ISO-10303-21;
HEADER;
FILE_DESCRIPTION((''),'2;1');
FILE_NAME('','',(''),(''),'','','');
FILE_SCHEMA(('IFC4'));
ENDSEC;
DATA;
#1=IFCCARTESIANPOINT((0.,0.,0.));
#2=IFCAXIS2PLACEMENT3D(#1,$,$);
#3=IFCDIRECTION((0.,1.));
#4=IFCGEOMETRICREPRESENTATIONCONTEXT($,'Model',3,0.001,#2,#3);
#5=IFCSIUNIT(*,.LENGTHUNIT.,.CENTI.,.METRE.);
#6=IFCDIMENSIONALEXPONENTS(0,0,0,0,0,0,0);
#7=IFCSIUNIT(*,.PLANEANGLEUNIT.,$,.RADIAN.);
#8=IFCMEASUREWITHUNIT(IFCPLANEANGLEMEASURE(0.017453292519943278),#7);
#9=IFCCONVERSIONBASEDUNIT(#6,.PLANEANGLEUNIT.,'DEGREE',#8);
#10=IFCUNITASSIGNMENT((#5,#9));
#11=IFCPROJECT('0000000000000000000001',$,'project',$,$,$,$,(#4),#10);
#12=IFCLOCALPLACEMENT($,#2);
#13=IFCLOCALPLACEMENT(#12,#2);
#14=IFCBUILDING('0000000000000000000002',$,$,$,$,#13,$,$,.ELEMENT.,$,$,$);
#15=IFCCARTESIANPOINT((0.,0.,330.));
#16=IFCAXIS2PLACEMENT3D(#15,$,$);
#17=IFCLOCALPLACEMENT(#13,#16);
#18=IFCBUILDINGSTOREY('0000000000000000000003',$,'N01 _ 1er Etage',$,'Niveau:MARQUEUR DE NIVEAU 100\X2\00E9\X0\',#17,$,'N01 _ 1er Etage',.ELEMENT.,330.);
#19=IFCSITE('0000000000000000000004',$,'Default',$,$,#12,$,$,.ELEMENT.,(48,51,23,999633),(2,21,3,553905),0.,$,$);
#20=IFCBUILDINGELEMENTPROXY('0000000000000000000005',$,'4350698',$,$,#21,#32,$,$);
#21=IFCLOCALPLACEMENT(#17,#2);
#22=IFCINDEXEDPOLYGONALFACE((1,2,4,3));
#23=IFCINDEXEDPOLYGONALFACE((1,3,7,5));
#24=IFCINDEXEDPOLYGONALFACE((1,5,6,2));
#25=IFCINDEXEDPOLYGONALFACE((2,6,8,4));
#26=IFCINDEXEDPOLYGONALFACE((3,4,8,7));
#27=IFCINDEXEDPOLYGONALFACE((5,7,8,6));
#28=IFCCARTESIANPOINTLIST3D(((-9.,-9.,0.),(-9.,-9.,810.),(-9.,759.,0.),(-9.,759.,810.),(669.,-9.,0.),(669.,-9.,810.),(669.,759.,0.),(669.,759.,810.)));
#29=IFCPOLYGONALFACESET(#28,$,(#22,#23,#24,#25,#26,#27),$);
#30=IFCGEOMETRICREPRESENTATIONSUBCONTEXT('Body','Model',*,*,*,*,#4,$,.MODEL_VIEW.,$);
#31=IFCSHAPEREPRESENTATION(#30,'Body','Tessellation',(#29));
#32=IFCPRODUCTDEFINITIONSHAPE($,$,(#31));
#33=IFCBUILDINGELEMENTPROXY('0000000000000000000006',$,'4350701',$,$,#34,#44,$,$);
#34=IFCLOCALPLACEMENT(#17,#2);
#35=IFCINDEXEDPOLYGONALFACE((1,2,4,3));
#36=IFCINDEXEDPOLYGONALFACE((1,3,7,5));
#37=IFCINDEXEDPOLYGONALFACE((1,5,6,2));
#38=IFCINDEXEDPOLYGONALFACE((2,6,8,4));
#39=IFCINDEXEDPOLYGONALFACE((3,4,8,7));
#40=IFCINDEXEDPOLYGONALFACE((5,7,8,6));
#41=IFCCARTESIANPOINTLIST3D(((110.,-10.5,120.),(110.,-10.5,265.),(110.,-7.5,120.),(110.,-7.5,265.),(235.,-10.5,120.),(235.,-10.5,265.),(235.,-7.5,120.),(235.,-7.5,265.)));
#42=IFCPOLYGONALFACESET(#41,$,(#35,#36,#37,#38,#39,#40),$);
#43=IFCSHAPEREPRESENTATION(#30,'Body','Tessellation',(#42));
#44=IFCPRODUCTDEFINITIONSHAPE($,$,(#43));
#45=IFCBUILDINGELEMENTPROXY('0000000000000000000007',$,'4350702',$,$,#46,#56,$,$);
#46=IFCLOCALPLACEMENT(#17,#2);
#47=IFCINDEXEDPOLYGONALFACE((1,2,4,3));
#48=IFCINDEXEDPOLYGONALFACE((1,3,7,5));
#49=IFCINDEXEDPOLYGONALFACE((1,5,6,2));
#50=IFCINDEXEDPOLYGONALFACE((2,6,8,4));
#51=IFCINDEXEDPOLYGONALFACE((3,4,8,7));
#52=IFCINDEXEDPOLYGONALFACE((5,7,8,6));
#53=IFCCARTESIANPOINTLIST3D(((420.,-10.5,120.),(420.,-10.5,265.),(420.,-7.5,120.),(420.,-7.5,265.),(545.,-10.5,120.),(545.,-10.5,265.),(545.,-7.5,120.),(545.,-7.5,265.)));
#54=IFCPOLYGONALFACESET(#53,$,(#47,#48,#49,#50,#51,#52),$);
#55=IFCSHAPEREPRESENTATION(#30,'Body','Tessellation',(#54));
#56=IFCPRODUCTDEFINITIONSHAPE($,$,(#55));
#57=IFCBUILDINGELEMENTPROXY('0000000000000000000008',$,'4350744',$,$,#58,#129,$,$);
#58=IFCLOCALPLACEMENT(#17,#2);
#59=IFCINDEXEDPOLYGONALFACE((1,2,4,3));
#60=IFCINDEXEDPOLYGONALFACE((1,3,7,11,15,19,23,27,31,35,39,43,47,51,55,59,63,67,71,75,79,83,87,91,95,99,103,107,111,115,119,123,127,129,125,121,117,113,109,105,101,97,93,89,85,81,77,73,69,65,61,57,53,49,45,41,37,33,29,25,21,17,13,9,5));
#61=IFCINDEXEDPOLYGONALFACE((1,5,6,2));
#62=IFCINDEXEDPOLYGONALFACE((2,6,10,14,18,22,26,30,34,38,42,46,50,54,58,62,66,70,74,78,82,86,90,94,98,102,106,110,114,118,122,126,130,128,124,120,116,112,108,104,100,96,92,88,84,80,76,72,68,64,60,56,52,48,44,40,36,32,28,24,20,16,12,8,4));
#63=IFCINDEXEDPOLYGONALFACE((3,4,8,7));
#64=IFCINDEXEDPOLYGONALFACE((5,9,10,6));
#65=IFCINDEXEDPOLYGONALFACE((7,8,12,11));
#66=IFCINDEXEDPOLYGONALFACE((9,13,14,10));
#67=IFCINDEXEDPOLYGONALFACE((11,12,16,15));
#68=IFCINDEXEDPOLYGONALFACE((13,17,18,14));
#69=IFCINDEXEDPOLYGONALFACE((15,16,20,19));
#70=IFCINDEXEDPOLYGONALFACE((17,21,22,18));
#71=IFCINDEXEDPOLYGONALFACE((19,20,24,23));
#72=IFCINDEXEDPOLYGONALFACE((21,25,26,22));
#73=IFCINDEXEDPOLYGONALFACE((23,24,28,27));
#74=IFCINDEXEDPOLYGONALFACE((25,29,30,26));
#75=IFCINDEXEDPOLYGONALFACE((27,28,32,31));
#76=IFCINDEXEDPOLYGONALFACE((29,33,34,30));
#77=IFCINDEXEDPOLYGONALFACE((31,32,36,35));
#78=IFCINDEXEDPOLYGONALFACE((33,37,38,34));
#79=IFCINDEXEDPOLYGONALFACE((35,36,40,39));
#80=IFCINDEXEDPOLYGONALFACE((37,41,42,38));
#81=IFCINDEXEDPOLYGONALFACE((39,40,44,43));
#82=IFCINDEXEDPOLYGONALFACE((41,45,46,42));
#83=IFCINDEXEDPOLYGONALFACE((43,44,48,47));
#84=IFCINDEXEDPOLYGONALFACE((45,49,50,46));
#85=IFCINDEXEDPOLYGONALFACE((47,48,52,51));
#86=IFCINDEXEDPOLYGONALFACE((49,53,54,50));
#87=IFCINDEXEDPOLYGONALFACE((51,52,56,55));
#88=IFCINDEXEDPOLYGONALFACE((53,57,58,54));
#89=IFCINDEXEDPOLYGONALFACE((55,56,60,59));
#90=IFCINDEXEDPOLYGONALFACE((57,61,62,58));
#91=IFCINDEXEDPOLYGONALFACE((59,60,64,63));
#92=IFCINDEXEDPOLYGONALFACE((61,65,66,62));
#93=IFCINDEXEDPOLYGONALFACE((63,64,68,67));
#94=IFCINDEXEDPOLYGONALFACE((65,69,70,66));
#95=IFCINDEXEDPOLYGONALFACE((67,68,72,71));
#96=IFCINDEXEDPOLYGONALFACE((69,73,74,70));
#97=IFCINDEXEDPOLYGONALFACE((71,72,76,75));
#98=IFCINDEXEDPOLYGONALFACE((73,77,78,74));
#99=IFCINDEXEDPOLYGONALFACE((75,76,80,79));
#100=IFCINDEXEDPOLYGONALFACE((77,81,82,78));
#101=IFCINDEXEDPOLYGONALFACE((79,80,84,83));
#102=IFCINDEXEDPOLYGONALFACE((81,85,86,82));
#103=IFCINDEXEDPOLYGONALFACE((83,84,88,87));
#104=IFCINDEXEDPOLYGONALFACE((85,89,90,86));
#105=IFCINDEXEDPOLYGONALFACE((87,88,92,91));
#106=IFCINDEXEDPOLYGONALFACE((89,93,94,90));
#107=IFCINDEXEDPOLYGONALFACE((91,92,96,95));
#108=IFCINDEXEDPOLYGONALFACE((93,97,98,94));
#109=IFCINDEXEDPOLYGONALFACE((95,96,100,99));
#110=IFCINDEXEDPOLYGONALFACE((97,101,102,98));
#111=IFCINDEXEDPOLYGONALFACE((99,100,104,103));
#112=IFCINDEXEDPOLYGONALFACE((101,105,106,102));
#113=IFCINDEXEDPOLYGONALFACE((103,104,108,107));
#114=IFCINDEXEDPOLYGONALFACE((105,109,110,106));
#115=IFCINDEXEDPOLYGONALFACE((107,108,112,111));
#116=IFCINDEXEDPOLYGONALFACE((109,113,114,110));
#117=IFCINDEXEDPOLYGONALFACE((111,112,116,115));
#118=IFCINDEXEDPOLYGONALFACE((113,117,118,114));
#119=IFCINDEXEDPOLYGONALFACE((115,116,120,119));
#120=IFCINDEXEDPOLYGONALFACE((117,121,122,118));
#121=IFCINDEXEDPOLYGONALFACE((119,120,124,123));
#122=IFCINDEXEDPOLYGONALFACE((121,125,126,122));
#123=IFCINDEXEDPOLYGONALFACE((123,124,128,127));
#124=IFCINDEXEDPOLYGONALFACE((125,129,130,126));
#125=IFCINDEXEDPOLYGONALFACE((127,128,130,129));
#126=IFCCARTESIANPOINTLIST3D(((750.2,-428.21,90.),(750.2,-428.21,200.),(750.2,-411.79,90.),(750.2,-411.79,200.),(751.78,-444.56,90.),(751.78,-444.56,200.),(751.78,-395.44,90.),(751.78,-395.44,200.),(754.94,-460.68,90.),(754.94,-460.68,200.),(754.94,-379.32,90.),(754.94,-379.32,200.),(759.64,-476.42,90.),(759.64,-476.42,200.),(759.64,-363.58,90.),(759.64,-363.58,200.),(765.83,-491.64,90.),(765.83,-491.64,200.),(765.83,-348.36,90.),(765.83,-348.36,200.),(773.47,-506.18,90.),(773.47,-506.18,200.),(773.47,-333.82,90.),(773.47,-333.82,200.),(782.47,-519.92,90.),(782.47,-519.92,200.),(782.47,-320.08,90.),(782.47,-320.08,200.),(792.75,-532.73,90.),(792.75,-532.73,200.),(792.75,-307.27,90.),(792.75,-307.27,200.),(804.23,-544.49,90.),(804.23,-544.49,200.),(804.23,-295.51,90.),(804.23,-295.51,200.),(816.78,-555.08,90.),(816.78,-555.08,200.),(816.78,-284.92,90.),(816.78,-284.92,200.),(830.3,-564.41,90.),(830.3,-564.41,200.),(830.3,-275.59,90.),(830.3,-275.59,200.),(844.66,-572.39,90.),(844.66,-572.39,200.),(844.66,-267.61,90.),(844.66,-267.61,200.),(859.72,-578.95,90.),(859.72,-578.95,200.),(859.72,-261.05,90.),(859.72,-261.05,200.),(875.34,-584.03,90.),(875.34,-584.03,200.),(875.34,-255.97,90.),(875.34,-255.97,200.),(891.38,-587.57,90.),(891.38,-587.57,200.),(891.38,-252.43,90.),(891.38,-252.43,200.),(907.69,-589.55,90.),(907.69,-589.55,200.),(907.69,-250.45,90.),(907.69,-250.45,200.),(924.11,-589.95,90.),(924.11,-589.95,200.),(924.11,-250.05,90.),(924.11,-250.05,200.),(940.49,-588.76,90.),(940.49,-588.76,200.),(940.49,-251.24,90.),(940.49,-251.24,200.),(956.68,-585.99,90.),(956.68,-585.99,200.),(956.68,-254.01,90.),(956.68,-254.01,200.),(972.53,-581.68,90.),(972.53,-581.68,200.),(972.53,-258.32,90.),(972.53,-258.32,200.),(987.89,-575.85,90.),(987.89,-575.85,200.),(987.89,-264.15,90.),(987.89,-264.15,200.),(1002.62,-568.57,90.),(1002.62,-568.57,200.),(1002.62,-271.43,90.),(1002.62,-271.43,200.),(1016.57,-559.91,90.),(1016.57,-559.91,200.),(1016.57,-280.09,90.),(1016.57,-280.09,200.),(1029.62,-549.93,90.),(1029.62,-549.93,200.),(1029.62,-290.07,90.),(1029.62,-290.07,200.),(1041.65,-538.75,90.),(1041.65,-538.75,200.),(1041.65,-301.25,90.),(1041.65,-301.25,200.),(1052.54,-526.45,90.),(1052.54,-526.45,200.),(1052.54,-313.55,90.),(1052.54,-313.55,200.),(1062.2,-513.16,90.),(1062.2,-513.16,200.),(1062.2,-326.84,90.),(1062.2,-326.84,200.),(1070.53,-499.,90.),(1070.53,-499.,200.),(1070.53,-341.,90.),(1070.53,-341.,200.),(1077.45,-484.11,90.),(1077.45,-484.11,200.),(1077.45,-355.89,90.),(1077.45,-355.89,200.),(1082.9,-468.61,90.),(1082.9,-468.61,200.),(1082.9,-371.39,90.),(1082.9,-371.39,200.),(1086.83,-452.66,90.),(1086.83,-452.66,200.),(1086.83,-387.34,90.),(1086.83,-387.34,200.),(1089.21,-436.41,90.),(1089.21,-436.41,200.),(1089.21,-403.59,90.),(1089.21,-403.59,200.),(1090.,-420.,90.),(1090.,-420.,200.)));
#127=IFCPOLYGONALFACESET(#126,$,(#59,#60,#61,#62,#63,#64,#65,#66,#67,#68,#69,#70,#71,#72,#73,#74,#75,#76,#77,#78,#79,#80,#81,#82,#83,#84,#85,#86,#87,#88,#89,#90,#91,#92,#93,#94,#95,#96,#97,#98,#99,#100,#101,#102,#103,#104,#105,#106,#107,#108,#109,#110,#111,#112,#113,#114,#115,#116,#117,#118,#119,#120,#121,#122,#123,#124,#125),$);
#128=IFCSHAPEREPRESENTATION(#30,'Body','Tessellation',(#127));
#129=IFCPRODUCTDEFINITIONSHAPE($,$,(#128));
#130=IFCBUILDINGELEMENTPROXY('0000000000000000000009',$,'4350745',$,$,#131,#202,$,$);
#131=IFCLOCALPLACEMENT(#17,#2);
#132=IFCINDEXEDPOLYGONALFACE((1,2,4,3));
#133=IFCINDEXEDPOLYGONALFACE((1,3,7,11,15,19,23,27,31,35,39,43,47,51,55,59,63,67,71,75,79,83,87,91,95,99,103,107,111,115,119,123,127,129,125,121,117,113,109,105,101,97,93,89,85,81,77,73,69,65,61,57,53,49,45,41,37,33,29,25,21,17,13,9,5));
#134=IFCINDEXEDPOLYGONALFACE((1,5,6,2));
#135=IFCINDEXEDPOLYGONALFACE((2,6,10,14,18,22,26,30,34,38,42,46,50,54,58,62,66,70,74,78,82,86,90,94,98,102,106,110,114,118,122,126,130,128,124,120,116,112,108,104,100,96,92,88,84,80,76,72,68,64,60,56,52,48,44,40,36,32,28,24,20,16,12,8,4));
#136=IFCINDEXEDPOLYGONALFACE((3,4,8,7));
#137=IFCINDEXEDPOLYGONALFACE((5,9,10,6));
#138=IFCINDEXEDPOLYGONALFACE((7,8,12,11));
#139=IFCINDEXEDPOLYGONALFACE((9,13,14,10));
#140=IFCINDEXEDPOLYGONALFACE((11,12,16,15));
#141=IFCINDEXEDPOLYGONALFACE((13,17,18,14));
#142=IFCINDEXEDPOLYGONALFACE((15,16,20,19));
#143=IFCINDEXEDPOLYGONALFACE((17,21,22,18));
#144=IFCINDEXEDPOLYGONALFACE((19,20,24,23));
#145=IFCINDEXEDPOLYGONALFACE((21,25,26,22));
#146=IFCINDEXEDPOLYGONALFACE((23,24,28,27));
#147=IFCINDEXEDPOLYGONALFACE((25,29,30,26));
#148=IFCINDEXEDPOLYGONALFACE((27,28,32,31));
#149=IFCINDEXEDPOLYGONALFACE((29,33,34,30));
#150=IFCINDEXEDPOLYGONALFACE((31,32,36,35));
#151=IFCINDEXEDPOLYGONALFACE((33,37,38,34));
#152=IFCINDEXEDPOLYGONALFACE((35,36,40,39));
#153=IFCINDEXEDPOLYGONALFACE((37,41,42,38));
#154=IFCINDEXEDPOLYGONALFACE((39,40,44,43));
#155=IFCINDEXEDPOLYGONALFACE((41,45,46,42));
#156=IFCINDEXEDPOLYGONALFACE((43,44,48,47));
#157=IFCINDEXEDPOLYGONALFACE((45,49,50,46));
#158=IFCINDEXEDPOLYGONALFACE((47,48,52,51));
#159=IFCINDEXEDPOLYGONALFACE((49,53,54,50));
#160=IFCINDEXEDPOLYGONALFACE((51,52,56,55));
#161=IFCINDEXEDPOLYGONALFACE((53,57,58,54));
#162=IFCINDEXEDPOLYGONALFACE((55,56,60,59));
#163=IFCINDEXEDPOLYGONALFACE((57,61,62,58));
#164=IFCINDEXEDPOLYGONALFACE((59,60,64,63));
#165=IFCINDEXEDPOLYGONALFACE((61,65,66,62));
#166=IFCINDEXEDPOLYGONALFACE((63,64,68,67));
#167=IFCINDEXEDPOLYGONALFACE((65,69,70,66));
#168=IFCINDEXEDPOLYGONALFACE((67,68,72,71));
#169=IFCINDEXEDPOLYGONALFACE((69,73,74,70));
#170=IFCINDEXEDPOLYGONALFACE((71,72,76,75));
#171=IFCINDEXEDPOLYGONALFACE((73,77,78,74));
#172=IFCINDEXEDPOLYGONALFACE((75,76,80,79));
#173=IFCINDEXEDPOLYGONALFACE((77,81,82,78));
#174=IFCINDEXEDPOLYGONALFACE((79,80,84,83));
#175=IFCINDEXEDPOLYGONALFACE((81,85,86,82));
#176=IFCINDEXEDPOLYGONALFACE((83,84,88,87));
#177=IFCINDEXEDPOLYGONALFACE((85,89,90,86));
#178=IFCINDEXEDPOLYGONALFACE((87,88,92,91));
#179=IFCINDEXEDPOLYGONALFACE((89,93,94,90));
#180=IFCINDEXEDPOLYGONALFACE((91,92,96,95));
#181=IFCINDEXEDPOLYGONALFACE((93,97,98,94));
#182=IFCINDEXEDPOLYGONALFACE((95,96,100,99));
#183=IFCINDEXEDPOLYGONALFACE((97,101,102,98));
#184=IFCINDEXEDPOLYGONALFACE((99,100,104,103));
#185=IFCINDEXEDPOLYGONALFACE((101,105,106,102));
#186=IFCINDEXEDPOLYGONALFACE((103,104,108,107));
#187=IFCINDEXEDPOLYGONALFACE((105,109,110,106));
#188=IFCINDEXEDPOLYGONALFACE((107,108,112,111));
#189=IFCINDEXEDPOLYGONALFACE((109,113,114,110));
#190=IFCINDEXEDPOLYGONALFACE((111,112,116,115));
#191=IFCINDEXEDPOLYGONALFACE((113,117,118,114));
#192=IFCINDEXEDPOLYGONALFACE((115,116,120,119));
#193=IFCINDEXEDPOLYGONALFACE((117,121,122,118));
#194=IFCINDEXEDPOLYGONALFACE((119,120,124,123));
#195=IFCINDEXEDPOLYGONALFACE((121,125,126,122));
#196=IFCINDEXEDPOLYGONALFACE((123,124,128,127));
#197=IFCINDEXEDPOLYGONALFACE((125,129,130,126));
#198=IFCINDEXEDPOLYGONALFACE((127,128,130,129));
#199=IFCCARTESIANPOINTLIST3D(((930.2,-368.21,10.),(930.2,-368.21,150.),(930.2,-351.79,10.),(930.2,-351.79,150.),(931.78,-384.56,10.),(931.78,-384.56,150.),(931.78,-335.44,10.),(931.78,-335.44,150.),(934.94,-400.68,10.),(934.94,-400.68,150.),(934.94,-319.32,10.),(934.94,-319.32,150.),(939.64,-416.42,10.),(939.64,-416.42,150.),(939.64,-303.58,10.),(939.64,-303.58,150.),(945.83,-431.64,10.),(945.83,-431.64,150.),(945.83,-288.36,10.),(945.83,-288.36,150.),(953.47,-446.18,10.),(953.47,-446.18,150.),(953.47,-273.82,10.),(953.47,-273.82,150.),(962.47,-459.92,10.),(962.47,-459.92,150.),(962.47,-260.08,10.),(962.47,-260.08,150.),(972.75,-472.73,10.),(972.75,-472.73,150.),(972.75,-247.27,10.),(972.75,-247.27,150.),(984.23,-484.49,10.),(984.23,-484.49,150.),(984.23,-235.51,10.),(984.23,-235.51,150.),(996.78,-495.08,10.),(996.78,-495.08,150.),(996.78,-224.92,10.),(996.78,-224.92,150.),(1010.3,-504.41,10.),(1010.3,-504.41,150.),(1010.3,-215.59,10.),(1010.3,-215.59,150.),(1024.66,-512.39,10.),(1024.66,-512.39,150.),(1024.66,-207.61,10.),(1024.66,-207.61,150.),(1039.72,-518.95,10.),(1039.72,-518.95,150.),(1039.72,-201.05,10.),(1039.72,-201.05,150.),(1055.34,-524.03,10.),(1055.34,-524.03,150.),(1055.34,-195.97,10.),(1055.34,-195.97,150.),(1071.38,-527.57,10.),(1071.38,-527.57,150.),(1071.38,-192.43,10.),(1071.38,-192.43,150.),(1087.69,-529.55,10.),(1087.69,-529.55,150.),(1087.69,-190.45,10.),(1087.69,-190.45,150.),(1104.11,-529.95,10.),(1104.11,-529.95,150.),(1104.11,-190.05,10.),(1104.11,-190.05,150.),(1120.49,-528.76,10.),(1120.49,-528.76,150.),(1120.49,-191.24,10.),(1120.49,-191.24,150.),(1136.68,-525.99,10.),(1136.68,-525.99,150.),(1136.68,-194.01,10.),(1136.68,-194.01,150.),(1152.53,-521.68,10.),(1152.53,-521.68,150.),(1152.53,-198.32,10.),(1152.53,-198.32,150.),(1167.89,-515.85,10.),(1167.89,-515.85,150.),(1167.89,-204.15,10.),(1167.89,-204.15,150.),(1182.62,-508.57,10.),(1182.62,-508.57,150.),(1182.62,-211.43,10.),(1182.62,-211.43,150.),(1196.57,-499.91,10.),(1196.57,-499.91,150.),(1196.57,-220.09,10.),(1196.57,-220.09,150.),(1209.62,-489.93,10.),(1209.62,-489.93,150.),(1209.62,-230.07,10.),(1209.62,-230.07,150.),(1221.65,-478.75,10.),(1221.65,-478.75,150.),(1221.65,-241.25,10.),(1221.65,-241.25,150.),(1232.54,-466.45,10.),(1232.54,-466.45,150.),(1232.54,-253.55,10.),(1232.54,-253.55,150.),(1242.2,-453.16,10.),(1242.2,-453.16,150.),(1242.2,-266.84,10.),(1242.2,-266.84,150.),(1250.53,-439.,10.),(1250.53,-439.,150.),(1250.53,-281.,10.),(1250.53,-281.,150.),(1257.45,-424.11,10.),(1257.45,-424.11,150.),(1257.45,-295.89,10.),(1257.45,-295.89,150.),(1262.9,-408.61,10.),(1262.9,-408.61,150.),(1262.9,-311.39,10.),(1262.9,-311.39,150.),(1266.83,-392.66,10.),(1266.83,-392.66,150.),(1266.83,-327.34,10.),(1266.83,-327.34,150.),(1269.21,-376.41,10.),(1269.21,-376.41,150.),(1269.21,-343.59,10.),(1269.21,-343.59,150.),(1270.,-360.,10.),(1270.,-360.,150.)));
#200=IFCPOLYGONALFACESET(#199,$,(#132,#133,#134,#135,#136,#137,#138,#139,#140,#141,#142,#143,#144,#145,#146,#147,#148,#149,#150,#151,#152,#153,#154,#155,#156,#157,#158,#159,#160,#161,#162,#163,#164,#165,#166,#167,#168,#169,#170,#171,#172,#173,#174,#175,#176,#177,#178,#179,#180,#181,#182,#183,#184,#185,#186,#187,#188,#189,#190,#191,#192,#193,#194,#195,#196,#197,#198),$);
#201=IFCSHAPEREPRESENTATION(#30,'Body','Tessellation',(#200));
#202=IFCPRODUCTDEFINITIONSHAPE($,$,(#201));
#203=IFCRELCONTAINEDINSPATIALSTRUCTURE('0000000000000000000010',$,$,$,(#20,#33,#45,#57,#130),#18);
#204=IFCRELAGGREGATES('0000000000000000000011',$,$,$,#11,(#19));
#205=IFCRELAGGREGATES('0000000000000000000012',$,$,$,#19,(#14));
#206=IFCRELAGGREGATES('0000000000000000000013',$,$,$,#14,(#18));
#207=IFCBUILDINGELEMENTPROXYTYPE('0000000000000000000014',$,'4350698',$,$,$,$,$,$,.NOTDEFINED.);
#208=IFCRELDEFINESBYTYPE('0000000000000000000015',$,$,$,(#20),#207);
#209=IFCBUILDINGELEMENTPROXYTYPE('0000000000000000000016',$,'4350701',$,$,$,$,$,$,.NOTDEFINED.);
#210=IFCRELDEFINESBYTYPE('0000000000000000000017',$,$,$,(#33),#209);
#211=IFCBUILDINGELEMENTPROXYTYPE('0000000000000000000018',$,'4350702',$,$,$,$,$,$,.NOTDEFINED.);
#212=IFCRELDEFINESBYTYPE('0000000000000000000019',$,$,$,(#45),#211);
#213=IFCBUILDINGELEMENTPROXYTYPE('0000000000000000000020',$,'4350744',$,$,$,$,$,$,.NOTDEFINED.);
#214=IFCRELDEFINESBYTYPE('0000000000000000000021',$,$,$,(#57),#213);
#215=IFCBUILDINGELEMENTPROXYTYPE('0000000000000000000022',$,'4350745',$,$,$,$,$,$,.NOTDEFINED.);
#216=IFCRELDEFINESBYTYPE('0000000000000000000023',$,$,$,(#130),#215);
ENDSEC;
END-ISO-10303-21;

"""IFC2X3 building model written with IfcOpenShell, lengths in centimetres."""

from ifc_helpers import new_model, entity, si_unit, converted_unit, direction, frame, frame_2d, origin, origin_2d_with_axis, place, context, subcontext, project, spatial, rectangle, circle, extrude, type_object, element, save


model = new_model("IFC2X3")

# Units and contexts
model_context = context("Model", 3, precision=0.001, world=origin(), true_north=direction((0.0, 1.0)))
body_context = subcontext(model_context, "Body", "Model", "MODEL_VIEW")
ifc_project = project(units=[si_unit("LENGTHUNIT", "METRE", prefix="CENTI"), converted_unit("PLANEANGLEUNIT", "DEGREE", entity("IfcPlaneAngleMeasure", 0.017453292519943278), si_unit("PLANEANGLEUNIT", "RADIAN"), dimensions=[0, 0, 0, 0, 0, 0, 0])], contexts=[model_context])

# Site, building, storey
site_placement = place(None, origin())
site = spatial("IfcSite", under=ifc_project, at=site_placement, Name="Default", CompositionType="ELEMENT", RefLatitude=(48, 51, 23, 999633), RefLongitude=(2, 21, 3, 553905), RefElevation=0.0)
building_placement = place(site_placement, origin())
building = spatial("IfcBuilding", under=site, at=building_placement, CompositionType="ELEMENT")
storey_placement = place(building_placement, frame((0.0, 0.0, 330.0)))
storey = spatial("IfcBuildingStorey", under=building, at=storey_placement, Name="N01 _ 1er Etage", ObjectType="Niveau:MARQUEUR DE NIVEAU 100é", LongName="N01 _ 1er Etage", CompositionType="ELEMENT", Elevation=330.0)

# Building element proxies
building_element_proxy_type_1 = type_object("IfcBuildingElementProxyType", Name="4350698", PredefinedType="NOTDEFINED")
proxy_1_placement = place(storey_placement, origin())
element("IfcBuildingElementProxy", 1, at=proxy_1_placement, inside=storey, type_object=building_element_proxy_type_1, Name="4350698", context=body_context, shape_type="SweptSolid", body=[
    extrude(rectangle(XDim=678.0, YDim=768.0, at=origin_2d_with_axis()), frame((330.0, 375.0, 0.0)), (0.0, 0.0, 1.0), 810.0),
])
building_element_proxy_type_2 = type_object("IfcBuildingElementProxyType", Name="4350701", PredefinedType="NOTDEFINED")
proxy_2_placement = place(storey_placement, origin())
element("IfcBuildingElementProxy", 2, at=proxy_2_placement, inside=storey, type_object=building_element_proxy_type_2, Name="4350701", context=body_context, shape_type="SweptSolid", body=[
    extrude(rectangle(XDim=125.0, YDim=3.0, at=frame_2d((0.0, 0.0), x_axis=(1.0, 0.0))), frame((172.5, -9.0, 120.0)), (0.0, 0.0, 1.0), 145.0),
])
building_element_proxy_type_3 = type_object("IfcBuildingElementProxyType", Name="4350702", PredefinedType="NOTDEFINED")
proxy_3_placement = place(storey_placement, origin())
element("IfcBuildingElementProxy", 3, at=proxy_3_placement, inside=storey, type_object=building_element_proxy_type_3, Name="4350702", context=body_context, shape_type="SweptSolid", body=[
    extrude(rectangle(XDim=125.0, YDim=3.0, at=frame_2d((0.0, 0.0), x_axis=(1.0, 0.0))), frame((482.5, -9.0, 120.0)), (0.0, 0.0, 1.0), 145.0),
])
building_element_proxy_type_4 = type_object("IfcBuildingElementProxyType", Name="4350744", PredefinedType="NOTDEFINED")
proxy_4_placement = place(storey_placement, origin())
element("IfcBuildingElementProxy", 4, at=proxy_4_placement, inside=storey, type_object=building_element_proxy_type_4, Name="4350744", context=body_context, shape_type="SweptSolid", body=[
    extrude(circle(Radius=170.0, at=origin_2d_with_axis()), frame((920.0, -420.0, 90.0)), (0.0, 0.0, 1.0), 110.0),
])
building_element_proxy_type_5 = type_object("IfcBuildingElementProxyType", Name="4350745", PredefinedType="NOTDEFINED")
proxy_5_placement = place(storey_placement, origin())
element("IfcBuildingElementProxy", 5, at=proxy_5_placement, inside=storey, type_object=building_element_proxy_type_5, Name="4350745", context=body_context, shape_type="SweptSolid", body=[
    extrude(circle(Radius=170.0, at=origin_2d_with_axis()), frame((1100.0, -360.0, 10.0)), (0.0, 0.0, 1.0), 140.0),
])

save(model, "model.ifc")
